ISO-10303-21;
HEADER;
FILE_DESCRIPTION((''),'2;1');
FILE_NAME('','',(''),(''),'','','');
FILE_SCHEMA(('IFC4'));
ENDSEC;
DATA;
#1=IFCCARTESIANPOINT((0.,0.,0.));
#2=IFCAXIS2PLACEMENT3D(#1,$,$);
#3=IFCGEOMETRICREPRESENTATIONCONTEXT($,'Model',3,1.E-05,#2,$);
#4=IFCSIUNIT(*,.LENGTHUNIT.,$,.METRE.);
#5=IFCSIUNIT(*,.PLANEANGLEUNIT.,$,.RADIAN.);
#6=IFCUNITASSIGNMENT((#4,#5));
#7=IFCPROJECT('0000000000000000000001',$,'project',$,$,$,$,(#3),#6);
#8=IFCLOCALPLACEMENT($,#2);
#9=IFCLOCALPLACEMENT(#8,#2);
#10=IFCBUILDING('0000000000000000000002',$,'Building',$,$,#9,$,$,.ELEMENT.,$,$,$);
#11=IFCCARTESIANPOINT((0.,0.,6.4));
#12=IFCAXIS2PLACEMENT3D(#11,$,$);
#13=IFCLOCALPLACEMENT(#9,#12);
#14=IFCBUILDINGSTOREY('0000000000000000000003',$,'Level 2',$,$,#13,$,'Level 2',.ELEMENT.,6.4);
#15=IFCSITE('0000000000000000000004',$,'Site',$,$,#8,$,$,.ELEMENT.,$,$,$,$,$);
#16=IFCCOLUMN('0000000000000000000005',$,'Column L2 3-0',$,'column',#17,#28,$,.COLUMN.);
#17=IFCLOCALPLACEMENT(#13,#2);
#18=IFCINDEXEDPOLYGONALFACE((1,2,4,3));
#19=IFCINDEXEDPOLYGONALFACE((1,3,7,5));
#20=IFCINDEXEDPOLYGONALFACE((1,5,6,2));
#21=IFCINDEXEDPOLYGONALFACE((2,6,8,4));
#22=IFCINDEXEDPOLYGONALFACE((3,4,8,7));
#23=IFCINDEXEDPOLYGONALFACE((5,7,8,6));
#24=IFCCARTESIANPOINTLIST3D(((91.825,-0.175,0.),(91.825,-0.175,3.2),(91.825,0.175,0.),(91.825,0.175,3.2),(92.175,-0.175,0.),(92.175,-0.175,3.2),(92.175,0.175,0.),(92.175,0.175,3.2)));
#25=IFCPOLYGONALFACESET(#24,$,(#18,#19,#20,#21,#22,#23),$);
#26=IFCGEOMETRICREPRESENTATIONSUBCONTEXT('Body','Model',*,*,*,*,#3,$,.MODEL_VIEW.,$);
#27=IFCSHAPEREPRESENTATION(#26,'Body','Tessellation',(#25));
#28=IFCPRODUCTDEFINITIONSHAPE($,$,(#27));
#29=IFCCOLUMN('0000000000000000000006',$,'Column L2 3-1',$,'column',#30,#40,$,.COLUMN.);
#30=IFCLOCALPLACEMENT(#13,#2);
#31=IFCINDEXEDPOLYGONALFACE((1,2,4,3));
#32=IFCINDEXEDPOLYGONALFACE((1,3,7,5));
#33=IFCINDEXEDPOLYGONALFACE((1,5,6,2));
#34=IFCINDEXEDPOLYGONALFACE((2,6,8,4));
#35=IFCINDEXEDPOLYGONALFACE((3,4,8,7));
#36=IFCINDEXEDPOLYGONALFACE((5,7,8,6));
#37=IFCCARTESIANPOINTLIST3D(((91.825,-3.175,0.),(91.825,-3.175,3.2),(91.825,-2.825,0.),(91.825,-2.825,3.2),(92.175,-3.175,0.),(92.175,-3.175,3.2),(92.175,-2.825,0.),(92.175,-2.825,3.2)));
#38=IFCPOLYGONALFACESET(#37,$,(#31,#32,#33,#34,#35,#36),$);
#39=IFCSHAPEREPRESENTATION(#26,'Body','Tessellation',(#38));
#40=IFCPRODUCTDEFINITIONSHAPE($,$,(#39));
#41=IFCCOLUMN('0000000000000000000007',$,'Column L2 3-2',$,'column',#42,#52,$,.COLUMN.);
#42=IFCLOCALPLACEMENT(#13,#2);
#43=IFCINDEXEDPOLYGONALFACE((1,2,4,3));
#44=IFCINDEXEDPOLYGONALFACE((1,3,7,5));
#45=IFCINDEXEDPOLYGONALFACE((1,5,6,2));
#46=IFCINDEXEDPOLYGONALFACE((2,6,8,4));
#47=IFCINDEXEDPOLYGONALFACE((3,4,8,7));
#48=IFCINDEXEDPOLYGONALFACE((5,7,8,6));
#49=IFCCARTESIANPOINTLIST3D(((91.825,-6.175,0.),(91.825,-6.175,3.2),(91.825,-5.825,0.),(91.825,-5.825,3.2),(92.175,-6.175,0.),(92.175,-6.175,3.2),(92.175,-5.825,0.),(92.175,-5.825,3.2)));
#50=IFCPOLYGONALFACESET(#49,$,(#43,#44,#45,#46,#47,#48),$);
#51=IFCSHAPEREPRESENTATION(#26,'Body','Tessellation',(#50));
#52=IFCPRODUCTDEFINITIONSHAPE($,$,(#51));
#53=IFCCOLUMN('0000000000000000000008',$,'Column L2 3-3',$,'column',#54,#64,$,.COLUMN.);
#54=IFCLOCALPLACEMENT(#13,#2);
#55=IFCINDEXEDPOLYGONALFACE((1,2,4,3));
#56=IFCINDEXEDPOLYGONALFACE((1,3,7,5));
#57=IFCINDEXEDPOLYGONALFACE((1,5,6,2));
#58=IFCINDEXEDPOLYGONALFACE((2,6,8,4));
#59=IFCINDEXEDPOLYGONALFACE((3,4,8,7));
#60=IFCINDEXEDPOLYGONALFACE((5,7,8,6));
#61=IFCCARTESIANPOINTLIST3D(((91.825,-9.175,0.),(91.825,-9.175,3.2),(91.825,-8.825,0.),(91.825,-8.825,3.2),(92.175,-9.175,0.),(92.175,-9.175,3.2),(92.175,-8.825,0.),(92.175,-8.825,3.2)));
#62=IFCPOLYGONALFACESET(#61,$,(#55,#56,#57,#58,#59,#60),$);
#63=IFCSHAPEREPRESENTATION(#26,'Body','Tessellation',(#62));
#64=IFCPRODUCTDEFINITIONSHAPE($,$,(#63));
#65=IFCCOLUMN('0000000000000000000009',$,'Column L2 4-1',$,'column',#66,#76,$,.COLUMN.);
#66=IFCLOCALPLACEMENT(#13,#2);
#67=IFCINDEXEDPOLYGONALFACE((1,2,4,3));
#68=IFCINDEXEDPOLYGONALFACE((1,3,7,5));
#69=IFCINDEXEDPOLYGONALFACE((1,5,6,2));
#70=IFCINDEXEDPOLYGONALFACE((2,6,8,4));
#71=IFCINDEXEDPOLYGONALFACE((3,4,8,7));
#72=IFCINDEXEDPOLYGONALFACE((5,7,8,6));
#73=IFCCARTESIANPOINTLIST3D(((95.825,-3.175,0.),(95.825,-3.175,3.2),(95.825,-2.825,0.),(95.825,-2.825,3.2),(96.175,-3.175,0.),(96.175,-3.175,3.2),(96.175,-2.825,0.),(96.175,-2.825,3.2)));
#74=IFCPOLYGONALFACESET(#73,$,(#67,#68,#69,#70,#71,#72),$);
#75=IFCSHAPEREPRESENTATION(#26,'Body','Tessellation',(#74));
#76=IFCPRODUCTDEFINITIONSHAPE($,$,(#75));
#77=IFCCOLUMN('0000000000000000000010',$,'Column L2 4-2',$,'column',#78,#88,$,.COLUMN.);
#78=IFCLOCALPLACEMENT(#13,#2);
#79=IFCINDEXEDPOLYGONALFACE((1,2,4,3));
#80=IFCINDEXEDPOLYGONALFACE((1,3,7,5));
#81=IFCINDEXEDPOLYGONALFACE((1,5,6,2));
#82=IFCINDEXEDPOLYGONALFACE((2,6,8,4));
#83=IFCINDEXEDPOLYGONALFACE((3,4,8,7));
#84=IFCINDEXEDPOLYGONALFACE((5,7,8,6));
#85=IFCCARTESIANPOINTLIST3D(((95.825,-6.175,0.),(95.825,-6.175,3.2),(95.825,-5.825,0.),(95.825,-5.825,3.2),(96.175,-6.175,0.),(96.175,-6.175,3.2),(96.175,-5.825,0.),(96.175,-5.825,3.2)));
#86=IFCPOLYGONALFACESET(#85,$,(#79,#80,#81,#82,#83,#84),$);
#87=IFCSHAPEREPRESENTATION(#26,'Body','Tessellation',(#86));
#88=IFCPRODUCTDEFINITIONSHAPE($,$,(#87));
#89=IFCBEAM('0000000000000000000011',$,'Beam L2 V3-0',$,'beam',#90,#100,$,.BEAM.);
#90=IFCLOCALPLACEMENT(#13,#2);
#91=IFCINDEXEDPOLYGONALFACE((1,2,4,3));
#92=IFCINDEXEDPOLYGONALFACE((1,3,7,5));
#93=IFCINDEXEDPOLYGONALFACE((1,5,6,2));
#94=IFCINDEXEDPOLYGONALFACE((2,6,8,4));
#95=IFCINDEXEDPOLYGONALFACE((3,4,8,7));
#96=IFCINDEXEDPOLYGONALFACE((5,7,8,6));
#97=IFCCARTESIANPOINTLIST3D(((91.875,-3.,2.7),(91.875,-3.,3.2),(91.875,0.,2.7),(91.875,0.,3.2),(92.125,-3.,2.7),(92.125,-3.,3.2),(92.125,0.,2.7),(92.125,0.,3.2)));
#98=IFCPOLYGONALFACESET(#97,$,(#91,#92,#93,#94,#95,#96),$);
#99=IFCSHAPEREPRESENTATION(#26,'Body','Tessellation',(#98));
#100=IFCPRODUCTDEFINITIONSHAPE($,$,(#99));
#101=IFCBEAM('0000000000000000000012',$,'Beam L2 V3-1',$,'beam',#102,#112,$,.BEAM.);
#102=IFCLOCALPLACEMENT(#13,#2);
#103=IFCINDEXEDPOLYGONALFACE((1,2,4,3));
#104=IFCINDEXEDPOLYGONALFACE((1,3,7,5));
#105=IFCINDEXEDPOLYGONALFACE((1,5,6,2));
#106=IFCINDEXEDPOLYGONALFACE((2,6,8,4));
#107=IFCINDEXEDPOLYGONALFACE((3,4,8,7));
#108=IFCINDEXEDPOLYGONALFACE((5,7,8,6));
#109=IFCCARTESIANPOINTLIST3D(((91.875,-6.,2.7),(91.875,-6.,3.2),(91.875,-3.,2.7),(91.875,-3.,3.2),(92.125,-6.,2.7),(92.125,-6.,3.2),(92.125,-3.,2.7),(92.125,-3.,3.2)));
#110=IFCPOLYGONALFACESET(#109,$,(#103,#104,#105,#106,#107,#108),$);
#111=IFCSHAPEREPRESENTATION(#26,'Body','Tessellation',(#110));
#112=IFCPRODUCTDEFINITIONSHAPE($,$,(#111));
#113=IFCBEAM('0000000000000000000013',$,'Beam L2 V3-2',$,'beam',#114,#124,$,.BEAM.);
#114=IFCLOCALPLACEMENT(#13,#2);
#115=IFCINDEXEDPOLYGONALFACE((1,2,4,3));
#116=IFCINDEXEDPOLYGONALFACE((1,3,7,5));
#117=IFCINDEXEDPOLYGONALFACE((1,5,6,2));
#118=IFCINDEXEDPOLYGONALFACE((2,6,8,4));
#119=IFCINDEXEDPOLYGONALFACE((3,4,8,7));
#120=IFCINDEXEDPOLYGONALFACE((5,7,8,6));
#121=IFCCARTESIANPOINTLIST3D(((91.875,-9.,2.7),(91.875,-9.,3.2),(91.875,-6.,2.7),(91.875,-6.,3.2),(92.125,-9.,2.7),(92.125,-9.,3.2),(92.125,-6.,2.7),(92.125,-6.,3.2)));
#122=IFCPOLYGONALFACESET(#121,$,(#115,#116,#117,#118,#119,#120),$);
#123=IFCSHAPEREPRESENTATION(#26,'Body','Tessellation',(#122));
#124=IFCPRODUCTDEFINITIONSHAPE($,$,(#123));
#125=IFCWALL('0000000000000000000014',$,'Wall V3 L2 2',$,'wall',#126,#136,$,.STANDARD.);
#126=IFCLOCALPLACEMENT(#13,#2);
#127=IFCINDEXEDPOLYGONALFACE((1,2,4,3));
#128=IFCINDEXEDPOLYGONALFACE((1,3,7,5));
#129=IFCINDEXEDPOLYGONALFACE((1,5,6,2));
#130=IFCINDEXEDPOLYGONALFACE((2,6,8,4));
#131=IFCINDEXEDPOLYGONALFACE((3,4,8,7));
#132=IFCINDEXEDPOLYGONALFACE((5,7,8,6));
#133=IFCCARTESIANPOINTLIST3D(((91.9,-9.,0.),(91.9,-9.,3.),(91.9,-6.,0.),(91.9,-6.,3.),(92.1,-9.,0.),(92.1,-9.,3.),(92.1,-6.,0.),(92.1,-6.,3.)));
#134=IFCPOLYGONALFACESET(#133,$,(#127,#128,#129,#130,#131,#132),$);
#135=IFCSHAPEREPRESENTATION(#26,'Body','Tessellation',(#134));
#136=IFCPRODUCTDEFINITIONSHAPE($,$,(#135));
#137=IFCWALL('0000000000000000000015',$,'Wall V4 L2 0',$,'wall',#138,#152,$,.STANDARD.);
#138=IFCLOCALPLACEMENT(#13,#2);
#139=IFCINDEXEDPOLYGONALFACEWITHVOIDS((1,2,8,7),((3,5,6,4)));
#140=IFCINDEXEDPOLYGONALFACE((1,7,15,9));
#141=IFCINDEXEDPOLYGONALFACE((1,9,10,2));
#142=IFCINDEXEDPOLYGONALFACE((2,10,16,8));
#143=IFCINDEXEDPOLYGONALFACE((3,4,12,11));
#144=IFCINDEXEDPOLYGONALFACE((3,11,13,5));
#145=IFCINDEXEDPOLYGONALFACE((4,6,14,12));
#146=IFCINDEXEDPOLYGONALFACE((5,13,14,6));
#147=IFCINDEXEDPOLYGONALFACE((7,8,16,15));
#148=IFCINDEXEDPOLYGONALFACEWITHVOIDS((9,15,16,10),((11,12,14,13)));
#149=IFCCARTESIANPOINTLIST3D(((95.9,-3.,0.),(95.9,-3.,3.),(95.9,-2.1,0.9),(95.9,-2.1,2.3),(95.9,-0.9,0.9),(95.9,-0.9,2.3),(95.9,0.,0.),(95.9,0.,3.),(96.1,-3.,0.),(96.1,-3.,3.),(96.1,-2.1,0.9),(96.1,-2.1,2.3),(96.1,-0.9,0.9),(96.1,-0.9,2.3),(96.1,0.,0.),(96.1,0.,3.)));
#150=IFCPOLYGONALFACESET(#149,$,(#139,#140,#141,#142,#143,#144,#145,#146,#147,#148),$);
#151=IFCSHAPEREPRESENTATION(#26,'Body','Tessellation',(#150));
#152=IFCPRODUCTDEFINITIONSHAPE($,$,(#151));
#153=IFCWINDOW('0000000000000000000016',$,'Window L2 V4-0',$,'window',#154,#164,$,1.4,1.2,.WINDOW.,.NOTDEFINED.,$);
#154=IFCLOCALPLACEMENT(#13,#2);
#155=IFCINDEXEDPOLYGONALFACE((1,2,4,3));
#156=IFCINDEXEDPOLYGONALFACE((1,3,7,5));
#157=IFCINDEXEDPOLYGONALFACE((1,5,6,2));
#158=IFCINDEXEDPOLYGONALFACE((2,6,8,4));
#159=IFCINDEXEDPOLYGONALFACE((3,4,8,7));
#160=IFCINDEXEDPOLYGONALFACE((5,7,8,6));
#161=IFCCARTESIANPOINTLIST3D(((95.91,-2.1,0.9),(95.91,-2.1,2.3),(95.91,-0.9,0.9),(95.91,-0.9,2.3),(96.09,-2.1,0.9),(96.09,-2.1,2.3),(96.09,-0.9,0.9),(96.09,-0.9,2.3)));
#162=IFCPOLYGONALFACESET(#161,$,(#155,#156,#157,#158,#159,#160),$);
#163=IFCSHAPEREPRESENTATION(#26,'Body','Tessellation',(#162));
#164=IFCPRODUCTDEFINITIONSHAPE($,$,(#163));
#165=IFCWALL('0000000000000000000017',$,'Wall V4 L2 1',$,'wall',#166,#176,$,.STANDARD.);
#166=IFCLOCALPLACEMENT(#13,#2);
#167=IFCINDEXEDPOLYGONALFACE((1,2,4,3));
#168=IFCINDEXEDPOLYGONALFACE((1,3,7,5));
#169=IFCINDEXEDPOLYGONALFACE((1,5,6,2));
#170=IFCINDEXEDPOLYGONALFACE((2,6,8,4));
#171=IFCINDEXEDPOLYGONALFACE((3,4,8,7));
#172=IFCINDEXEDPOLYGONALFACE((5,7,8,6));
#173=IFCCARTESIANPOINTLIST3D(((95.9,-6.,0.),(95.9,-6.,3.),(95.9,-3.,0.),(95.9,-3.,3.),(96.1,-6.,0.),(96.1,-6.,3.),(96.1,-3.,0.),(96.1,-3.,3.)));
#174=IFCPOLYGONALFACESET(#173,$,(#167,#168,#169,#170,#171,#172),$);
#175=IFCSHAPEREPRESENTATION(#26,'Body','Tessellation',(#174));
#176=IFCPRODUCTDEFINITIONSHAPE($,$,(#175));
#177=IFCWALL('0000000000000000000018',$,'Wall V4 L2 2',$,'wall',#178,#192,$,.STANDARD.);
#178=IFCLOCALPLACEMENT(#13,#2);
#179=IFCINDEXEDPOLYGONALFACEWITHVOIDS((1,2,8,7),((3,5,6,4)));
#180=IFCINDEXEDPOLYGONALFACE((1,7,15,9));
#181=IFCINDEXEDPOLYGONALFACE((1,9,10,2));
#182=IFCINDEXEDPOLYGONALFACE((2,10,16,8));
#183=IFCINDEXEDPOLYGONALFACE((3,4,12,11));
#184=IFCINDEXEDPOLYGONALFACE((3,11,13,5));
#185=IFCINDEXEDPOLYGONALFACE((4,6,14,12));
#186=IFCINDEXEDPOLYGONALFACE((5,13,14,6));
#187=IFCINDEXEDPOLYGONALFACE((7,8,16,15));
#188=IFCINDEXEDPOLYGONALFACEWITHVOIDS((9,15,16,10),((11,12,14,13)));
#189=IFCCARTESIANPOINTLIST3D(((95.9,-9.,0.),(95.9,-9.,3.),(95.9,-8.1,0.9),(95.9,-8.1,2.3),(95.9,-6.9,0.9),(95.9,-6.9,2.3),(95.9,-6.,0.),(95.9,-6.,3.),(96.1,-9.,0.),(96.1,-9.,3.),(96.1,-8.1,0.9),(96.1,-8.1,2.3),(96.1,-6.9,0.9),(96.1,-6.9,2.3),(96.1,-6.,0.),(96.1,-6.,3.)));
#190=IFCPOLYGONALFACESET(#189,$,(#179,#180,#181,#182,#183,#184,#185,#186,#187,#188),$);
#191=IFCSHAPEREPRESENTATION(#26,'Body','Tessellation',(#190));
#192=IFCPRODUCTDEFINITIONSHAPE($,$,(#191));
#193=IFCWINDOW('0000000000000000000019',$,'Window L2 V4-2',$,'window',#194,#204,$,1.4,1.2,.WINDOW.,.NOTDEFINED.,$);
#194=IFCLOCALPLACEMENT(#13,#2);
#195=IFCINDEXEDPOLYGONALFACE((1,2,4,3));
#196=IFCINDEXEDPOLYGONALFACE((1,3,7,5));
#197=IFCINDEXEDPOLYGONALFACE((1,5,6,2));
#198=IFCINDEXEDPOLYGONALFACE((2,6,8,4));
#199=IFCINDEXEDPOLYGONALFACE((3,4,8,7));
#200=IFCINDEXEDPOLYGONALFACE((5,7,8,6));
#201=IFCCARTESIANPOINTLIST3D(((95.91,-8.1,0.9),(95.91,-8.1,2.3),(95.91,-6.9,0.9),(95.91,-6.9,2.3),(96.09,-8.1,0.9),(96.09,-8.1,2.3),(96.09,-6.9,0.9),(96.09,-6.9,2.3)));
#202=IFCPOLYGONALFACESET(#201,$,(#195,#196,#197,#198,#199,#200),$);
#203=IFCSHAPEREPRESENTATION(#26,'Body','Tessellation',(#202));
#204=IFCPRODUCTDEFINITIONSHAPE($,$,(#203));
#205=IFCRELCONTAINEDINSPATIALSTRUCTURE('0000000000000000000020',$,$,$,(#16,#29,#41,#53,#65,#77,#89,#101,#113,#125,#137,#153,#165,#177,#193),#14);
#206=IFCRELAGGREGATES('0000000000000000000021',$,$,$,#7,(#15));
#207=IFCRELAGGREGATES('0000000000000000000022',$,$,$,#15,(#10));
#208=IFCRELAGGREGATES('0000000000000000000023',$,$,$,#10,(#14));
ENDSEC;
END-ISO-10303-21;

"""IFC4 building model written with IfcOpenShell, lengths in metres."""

from ifc_helpers import new_model, si_unit, frame, frame_2d, origin, origin_2d, place, context, subcontext, project, spatial, rectangle, extrude, element, fill, save


model = new_model("IFC4")

# Units and contexts
model_context = context("Model", 3, precision=1e-05, world=origin())
body_context = subcontext(model_context, "Body", "Model", "MODEL_VIEW")
ifc_project = project(units=[si_unit("LENGTHUNIT", "METRE"), si_unit("PLANEANGLEUNIT", "RADIAN")], contexts=[model_context])

# Site, building, storey
site_placement = place(None, origin())
site = spatial("IfcSite", under=ifc_project, at=site_placement, Name="Site", CompositionType="ELEMENT")
building_placement = place(site_placement, origin())
building = spatial("IfcBuilding", under=site, at=building_placement, Name="Building", CompositionType="ELEMENT")
storey_placement = place(building_placement, frame((0.0, 0.0, 6.4)))
storey = spatial("IfcBuildingStorey", under=building, at=storey_placement, Name="Level 2", LongName="Level 2", CompositionType="ELEMENT", Elevation=6.4)

# Columns
for number, where, name in (
    (1, (92.0, 0.0, 0.0), "Column L2 3-0"),
    (2, (92.0, -3.0, 0.0), "Column L2 3-1"),
    (3, (92.0, -6.0, 0.0), "Column L2 3-2"),
    (4, (92.0, -9.0, 0.0), "Column L2 3-3"),
    (5, (96.0, -3.0, 0.0), "Column L2 4-1"),
    (6, (96.0, -6.0, 0.0), "Column L2 4-2"),
):
    element("IfcColumn", number, at=place(storey_placement, frame(where)), inside=storey, Name=name, ObjectType="column", PredefinedType="COLUMN", context=body_context, shape_type="SweptSolid", body=[
        extrude(rectangle(XDim=0.35, YDim=0.35, at=origin_2d()), origin(), (0.0, 0.0, 1.0), 3.2),
    ])

# Beams
for number, where, z_axis, x_axis, name in (
    (7, (92.0, 0.0, 2.95), (0.0, -1.0, 0.0), (0.0, 0.0, 1.0), "Beam L2 V3-0"),
    (8, (92.0, -3.0, 2.95), (0.0, -1.0, 0.0), (0.0, 0.0, 1.0), "Beam L2 V3-1"),
    (9, (92.0, -6.0, 2.95), (0.0, -1.0, 0.0), (0.0, 0.0, 1.0), "Beam L2 V3-2"),
):
    element("IfcBeam", number, at=place(storey_placement, frame(where, z_axis=z_axis, x_axis=x_axis)), inside=storey, Name=name, ObjectType="beam", PredefinedType="BEAM", context=body_context, shape_type="SweptSolid", body=[
        extrude(rectangle(XDim=0.5, YDim=0.25, at=origin_2d()), origin(), (0.0, 0.0, 1.0), 3.0),
    ])

# Wall
wall_1_placement = place(storey_placement, frame((92.0, -6.0, 0.0), z_axis=(0.0, 0.0, 1.0), x_axis=(0.0, -1.0, 0.0)))
element("IfcWall", 10, at=wall_1_placement, inside=storey, Name="Wall V3 L2 2", ObjectType="wall", PredefinedType="STANDARD", context=body_context, shape_type="SweptSolid", body=[
    extrude(rectangle(XDim=3.0, YDim=0.2, at=frame_2d((1.5, 0.0))), origin(), (0.0, 0.0, 1.0), 3.0),
])

# Wall, opening, window
wall_2_placement = place(storey_placement, frame((96.0, 0.0, 0.0), z_axis=(0.0, 0.0, 1.0), x_axis=(0.0, -1.0, 0.0)))
wall_2 = element("IfcWall", 11, at=wall_2_placement, inside=storey, Name="Wall V4 L2 0", ObjectType="wall", PredefinedType="STANDARD", context=body_context, shape_type="SweptSolid", body=[
    extrude(rectangle(XDim=3.0, YDim=0.2, at=frame_2d((1.5, 0.0))), origin(), (0.0, 0.0, 1.0), 3.0),
])
opening_1_placement = place(storey_placement, frame((96.0, -1.5, 0.9), z_axis=(0.0, 0.0, 1.0), x_axis=(0.0, -1.0, 0.0)))
opening_1 = element("IfcOpeningElement", 12, at=opening_1_placement, cuts=wall_2, ObjectType="Opening", PredefinedType="OPENING", context=body_context, shape_type="SweptSolid", body=[
    extrude(rectangle(XDim=1.2, YDim=0.22, at=origin_2d()), origin(), (0.0, 0.0, 1.0), 1.4),
])
window_1_placement = place(storey_placement, frame((96.0, -1.5, 0.9), z_axis=(0.0, 0.0, 1.0), x_axis=(0.0, -1.0, 0.0)))
window_1 = element("IfcWindow", 13, at=window_1_placement, inside=storey, Name="Window L2 V4-0", ObjectType="window", OverallHeight=1.4, OverallWidth=1.2, PartitioningType="NOTDEFINED", PredefinedType="WINDOW", context=body_context, shape_type="SweptSolid", body=[
    extrude(rectangle(XDim=1.2, YDim=0.18, at=origin_2d()), origin(), (0.0, 0.0, 1.0), 1.4),
])
fill(opening_1, window_1)

# Wall
wall_3_placement = place(storey_placement, frame((96.0, -3.0, 0.0), z_axis=(0.0, 0.0, 1.0), x_axis=(0.0, -1.0, 0.0)))
element("IfcWall", 14, at=wall_3_placement, inside=storey, Name="Wall V4 L2 1", ObjectType="wall", PredefinedType="STANDARD", context=body_context, shape_type="SweptSolid", body=[
    extrude(rectangle(XDim=3.0, YDim=0.2, at=frame_2d((1.5, 0.0))), origin(), (0.0, 0.0, 1.0), 3.0),
])

# Wall, opening, window
wall_4_placement = place(storey_placement, frame((96.0, -6.0, 0.0), z_axis=(0.0, 0.0, 1.0), x_axis=(0.0, -1.0, 0.0)))
wall_4 = element("IfcWall", 15, at=wall_4_placement, inside=storey, Name="Wall V4 L2 2", ObjectType="wall", PredefinedType="STANDARD", context=body_context, shape_type="SweptSolid", body=[
    extrude(rectangle(XDim=3.0, YDim=0.2, at=frame_2d((1.5, 0.0))), origin(), (0.0, 0.0, 1.0), 3.0),
])
opening_2_placement = place(storey_placement, frame((96.0, -7.5, 0.9), z_axis=(0.0, 0.0, 1.0), x_axis=(0.0, -1.0, 0.0)))
opening_2 = element("IfcOpeningElement", 16, at=opening_2_placement, cuts=wall_4, ObjectType="Opening", PredefinedType="OPENING", context=body_context, shape_type="SweptSolid", body=[
    extrude(rectangle(XDim=1.2, YDim=0.22, at=origin_2d()), origin(), (0.0, 0.0, 1.0), 1.4),
])
window_2_placement = place(storey_placement, frame((96.0, -7.5, 0.9), z_axis=(0.0, 0.0, 1.0), x_axis=(0.0, -1.0, 0.0)))
window_2 = element("IfcWindow", 17, at=window_2_placement, inside=storey, Name="Window L2 V4-2", ObjectType="window", OverallHeight=1.4, OverallWidth=1.2, PartitioningType="NOTDEFINED", PredefinedType="WINDOW", context=body_context, shape_type="SweptSolid", body=[
    extrude(rectangle(XDim=1.2, YDim=0.18, at=origin_2d()), origin(), (0.0, 0.0, 1.0), 1.4),
])
fill(opening_2, window_2)

save(model, "model.ifc")
